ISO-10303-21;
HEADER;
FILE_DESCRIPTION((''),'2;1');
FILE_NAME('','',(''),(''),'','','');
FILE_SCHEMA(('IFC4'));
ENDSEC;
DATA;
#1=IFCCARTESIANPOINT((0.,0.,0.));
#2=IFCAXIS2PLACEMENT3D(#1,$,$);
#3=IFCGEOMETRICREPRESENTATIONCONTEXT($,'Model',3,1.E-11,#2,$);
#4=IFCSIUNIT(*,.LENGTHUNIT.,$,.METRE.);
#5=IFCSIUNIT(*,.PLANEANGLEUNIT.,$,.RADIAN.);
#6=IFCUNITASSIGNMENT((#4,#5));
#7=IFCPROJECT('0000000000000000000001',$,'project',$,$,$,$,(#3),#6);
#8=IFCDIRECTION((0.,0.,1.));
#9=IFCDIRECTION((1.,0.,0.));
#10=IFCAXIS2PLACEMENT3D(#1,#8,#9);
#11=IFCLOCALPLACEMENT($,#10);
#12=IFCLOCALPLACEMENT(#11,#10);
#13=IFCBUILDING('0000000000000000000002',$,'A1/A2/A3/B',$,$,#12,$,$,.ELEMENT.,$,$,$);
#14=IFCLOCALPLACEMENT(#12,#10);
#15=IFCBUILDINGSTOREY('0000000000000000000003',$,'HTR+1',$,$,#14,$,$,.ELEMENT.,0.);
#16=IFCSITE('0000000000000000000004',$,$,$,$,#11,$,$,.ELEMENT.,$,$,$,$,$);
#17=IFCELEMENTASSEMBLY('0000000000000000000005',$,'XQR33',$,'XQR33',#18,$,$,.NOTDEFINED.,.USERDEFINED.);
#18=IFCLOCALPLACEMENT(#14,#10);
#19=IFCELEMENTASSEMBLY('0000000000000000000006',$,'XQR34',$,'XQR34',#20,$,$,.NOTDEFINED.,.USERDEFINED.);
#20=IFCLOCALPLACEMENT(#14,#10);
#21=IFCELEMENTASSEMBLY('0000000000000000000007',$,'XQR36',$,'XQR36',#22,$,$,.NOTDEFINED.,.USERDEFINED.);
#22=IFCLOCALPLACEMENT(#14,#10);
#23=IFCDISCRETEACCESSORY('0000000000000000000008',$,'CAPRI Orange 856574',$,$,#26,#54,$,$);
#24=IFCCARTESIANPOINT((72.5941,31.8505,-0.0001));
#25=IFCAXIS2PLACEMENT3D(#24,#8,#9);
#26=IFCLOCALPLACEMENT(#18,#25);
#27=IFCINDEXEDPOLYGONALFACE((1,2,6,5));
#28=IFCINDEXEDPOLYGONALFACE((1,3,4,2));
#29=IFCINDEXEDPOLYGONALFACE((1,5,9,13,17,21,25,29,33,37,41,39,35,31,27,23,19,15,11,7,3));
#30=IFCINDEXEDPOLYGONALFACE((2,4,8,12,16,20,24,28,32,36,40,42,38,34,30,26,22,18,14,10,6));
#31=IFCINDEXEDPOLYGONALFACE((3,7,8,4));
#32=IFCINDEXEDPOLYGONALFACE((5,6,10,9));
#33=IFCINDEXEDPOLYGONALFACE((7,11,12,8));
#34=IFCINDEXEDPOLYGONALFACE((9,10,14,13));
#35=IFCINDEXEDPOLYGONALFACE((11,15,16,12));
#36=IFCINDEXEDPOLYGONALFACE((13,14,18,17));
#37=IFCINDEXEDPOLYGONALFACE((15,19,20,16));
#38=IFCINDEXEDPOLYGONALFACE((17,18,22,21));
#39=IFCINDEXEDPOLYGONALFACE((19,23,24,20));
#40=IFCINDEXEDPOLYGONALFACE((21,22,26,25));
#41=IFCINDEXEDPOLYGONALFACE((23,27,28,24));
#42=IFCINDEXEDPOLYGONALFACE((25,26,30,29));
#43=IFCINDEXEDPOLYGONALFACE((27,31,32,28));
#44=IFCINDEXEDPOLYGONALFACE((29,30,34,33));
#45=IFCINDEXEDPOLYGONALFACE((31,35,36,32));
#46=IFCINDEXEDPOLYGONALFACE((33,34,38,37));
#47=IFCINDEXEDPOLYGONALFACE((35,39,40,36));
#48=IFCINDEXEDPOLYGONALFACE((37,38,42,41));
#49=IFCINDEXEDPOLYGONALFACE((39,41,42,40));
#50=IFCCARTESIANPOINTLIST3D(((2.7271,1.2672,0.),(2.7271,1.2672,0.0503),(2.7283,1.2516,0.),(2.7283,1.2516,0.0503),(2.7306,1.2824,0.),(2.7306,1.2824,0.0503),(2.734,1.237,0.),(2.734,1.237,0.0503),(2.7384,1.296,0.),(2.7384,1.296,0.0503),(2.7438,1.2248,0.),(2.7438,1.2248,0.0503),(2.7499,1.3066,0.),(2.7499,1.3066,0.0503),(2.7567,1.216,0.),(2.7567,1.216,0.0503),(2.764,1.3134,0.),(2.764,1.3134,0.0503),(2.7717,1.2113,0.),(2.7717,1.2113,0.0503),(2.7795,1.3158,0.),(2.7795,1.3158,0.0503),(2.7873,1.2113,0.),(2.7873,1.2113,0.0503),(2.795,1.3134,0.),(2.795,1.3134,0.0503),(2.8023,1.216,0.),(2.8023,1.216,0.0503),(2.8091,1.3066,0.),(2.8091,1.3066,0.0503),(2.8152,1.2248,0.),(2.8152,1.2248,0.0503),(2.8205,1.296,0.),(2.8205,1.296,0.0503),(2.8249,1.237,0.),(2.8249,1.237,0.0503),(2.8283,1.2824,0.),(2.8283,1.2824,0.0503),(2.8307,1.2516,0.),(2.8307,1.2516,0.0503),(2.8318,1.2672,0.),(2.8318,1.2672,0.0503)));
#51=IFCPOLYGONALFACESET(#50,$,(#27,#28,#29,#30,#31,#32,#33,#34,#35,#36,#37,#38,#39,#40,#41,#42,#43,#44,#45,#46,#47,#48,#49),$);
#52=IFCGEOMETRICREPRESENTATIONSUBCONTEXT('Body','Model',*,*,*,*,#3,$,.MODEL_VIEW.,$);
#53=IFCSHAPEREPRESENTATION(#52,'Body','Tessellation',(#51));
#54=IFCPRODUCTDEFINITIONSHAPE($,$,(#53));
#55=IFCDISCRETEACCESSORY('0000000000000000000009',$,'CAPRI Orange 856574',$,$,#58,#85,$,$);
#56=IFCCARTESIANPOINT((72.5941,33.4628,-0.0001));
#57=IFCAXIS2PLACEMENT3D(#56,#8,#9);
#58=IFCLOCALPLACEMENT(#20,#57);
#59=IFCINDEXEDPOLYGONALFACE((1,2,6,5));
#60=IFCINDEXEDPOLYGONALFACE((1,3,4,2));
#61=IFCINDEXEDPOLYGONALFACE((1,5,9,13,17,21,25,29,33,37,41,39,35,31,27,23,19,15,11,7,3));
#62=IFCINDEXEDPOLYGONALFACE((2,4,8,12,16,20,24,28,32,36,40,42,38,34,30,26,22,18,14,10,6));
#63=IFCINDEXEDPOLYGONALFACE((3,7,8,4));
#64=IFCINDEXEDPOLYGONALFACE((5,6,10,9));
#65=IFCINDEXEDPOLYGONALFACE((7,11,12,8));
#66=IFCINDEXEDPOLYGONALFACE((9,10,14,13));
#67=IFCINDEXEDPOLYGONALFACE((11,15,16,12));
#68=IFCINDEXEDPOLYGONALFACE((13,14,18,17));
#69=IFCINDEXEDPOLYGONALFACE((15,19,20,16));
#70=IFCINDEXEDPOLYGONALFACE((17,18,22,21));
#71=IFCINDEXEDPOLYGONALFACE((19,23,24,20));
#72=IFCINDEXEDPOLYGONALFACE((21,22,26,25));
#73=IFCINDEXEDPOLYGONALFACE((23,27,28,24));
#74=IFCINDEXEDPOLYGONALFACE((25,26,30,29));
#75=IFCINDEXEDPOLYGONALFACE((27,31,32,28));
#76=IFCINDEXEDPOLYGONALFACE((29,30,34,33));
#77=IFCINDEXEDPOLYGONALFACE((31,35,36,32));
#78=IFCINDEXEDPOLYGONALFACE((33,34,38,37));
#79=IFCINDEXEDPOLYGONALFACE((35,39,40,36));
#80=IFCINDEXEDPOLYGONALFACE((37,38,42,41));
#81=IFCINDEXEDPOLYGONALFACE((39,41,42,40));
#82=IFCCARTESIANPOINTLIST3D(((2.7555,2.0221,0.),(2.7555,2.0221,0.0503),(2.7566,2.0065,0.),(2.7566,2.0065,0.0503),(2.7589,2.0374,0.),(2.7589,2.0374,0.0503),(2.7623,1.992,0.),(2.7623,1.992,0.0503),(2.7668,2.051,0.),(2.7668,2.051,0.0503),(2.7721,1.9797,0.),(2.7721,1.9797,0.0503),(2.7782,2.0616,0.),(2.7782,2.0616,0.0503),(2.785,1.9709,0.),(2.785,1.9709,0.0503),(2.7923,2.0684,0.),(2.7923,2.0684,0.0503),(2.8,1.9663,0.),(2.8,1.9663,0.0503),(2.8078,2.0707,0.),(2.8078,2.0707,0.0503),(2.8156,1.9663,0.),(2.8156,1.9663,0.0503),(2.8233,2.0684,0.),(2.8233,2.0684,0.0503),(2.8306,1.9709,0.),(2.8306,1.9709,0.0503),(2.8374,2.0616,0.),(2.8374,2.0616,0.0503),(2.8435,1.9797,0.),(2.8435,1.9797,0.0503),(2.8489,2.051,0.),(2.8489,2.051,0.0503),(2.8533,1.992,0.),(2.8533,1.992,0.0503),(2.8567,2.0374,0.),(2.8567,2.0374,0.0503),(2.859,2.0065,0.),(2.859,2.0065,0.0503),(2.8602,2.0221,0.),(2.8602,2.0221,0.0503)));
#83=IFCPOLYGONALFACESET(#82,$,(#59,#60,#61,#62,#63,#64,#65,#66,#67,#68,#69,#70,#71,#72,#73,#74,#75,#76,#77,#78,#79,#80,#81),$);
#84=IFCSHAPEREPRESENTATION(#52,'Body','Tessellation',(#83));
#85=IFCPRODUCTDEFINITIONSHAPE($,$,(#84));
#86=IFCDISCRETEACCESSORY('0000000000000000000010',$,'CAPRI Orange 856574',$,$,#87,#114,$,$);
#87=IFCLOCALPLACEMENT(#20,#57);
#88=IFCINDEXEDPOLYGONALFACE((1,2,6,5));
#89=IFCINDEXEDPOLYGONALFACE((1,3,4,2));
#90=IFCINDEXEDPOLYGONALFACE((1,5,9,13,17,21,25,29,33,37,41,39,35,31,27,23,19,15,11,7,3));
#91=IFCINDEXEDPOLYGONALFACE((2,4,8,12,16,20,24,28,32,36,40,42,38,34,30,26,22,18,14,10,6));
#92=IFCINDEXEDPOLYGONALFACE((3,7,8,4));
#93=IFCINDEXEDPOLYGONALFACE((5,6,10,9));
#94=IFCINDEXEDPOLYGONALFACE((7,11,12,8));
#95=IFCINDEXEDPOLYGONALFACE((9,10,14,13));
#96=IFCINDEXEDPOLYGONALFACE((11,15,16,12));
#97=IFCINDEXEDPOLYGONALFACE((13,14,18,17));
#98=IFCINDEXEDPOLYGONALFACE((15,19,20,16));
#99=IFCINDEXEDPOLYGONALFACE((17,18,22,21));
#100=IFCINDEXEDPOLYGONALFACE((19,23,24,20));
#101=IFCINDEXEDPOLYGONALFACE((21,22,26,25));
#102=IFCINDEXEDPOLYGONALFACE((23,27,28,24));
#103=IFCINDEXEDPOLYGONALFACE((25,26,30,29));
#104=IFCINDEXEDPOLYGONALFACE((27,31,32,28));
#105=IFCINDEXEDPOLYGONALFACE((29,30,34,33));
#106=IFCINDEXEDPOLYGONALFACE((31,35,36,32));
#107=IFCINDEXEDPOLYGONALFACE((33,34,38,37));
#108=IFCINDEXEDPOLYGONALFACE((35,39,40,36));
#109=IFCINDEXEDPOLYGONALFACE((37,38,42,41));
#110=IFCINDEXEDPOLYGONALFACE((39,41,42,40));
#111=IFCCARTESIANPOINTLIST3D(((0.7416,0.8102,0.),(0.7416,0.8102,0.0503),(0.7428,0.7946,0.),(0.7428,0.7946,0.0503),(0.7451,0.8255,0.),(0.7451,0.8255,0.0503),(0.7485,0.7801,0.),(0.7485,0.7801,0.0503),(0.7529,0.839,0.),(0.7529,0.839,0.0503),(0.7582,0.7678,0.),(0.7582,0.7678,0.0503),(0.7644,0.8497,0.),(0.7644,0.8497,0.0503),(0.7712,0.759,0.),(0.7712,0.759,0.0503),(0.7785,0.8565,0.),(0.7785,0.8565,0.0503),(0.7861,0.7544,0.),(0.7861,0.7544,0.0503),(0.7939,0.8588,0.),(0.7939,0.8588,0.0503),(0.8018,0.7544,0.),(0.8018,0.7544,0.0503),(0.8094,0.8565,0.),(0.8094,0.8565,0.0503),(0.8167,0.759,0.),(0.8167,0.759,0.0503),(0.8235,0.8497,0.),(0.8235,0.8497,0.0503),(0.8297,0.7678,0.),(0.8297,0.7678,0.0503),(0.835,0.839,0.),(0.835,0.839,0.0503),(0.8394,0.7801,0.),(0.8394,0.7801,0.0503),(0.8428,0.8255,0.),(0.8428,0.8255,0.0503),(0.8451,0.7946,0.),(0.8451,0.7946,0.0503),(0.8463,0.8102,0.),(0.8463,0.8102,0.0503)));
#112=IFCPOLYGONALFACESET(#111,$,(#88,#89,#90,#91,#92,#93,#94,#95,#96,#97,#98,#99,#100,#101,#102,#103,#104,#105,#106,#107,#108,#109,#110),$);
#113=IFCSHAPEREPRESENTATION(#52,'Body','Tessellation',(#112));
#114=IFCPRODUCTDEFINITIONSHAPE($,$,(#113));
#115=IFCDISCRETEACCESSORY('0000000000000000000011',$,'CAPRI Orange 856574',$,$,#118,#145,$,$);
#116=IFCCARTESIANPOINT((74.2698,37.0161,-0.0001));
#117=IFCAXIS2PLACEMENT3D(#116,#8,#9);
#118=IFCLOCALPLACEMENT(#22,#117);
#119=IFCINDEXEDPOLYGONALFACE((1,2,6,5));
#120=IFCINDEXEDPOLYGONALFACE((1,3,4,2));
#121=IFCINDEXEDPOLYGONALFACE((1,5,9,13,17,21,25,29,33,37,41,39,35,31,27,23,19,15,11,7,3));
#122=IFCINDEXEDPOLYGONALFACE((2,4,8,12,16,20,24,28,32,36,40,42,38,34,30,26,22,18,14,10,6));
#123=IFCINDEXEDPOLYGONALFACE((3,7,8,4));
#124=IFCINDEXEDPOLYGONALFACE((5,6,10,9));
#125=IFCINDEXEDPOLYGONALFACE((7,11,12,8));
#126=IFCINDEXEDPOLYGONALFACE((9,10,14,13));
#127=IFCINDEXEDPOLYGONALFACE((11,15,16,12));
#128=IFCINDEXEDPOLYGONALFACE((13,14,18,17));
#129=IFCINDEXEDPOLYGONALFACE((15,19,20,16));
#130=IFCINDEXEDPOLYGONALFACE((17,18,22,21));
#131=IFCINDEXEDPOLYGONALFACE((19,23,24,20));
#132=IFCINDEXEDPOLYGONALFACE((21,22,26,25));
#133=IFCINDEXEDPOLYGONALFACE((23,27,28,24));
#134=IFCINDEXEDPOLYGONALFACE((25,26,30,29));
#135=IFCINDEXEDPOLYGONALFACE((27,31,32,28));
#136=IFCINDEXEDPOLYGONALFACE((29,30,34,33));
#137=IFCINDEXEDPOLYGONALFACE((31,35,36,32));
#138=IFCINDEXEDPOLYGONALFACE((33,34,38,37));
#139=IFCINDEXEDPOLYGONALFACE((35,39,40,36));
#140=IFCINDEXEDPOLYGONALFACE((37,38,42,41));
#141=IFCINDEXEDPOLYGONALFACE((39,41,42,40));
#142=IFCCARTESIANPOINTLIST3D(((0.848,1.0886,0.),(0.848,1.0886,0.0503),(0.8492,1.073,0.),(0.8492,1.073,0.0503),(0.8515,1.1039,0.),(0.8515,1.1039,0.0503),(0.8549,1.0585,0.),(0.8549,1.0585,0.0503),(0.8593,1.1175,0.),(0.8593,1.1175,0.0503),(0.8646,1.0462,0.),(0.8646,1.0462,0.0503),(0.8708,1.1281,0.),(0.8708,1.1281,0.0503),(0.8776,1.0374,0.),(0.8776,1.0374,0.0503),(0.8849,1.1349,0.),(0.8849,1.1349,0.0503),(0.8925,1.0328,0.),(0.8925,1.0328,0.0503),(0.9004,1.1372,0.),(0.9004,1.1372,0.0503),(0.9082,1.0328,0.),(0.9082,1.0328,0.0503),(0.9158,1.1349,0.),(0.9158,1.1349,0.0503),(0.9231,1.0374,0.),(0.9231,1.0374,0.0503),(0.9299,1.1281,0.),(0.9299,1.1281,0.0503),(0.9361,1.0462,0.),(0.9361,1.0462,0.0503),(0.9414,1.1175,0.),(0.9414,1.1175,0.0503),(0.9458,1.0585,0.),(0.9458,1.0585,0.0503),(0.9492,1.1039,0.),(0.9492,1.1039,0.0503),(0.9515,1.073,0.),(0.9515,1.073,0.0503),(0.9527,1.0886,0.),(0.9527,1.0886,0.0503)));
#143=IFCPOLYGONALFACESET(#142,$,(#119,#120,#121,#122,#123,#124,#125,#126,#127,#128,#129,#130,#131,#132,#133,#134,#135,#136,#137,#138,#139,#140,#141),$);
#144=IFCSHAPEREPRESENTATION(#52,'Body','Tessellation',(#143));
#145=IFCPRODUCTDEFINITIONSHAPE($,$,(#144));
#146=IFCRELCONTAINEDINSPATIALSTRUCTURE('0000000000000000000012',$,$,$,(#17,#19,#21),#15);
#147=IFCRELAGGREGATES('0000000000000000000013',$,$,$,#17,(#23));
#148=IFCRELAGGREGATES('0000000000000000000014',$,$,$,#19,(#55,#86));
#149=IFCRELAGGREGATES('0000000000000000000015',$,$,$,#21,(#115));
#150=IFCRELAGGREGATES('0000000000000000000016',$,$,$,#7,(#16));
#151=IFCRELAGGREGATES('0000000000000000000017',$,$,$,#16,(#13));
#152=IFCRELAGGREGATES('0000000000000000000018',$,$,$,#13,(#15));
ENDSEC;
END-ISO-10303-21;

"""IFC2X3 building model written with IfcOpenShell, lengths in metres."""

from ifc_helpers import new_model, si_unit, frame, frame_2d, origin, origin_with_axes, place, context, subcontext, project, spatial, circle, extrude, element, aggregate, save


model = new_model("IFC2X3")

# Units and contexts
model_context = context("Model", 3, precision=1e-11, world=origin())
body_context = subcontext(model_context, "Body", "Model", "MODEL_VIEW")
ifc_project = project(units=[si_unit("LENGTHUNIT", "METRE"), si_unit("PLANEANGLEUNIT", "RADIAN")], contexts=[model_context])

# Site, building, storey
site_placement = place(None, origin_with_axes())
site = spatial("IfcSite", under=ifc_project, at=site_placement, CompositionType="ELEMENT")
building_placement = place(site_placement, origin_with_axes())
building = spatial("IfcBuilding", under=site, at=building_placement, Name="A1/A2/A3/B", CompositionType="ELEMENT")
storey_placement = place(building_placement, origin_with_axes())
storey = spatial("IfcBuildingStorey", under=building, at=storey_placement, Name="HTR+1", CompositionType="ELEMENT", Elevation=0.0)

# Element assembly
assembly_1_placement = place(storey_placement, origin_with_axes())
assembly_1 = element("IfcElementAssembly", 1, at=assembly_1_placement, inside=storey, Name="XQR33", ObjectType="XQR33", AssemblyPlace="NOTDEFINED", PredefinedType="USERDEFINED")

# Element assembly
assembly_2_placement = place(storey_placement, origin_with_axes())
assembly_2 = element("IfcElementAssembly", 2, at=assembly_2_placement, inside=storey, Name="XQR34", ObjectType="XQR34", AssemblyPlace="NOTDEFINED", PredefinedType="USERDEFINED")

# Element assembly
assembly_3_placement = place(storey_placement, origin_with_axes())
assembly_3 = element("IfcElementAssembly", 3, at=assembly_3_placement, inside=storey, Name="XQR36", ObjectType="XQR36", AssemblyPlace="NOTDEFINED", PredefinedType="USERDEFINED")

# Discrete accessory
discrete_accessory_1_placement = place(assembly_1_placement, frame((72.5941, 31.8505, -0.0001), z_axis=(0.0, 0.0, 1.0), x_axis=(1.0, 0.0, 0.0)))
discrete_accessory_1 = element("IfcDiscreteAccessory", 4, at=discrete_accessory_1_placement, Name="CAPRI Orange 856574", context=body_context, shape_type="SweptSolid", body=[
    extrude(circle(Radius=0.0525, at=frame_2d((1.2633, -2.7795), x_axis=(1.0, 0.0))), frame((0.0, 0.0, 0.0), z_axis=(0.0, 0.0, 1.0), x_axis=(0.0, 1.0, 0.0)), (0.0, 0.0, 1.0), 0.0503),
])

aggregate(assembly_1, [discrete_accessory_1])

# Discrete accessories
discrete_accessory_2_placement = place(assembly_2_placement, frame((72.5941, 33.4628, -0.0001), z_axis=(0.0, 0.0, 1.0), x_axis=(1.0, 0.0, 0.0)))
discrete_accessory_2 = element("IfcDiscreteAccessory", 5, at=discrete_accessory_2_placement, Name="CAPRI Orange 856574", context=body_context, shape_type="SweptSolid", body=[
    extrude(circle(Radius=0.0525, at=frame_2d((2.0182, -2.8078), x_axis=(1.0, 0.0))), frame((0.0, 0.0, 0.0), z_axis=(0.0, 0.0, 1.0), x_axis=(0.0, 1.0, 0.0)), (0.0, 0.0, 1.0), 0.0503),
])
discrete_accessory_3_placement = place(assembly_2_placement, frame((72.5941, 33.4628, -0.0001), z_axis=(0.0, 0.0, 1.0), x_axis=(1.0, 0.0, 0.0)))
discrete_accessory_3 = element("IfcDiscreteAccessory", 6, at=discrete_accessory_3_placement, Name="CAPRI Orange 856574", context=body_context, shape_type="SweptSolid", body=[
    extrude(circle(Radius=0.0525, at=frame_2d((0.8063, -0.7939), x_axis=(1.0, 0.0))), frame((0.0, 0.0, 0.0), z_axis=(0.0, 0.0, 1.0), x_axis=(0.0, 1.0, 0.0)), (0.0, 0.0, 1.0), 0.0503),
])

aggregate(assembly_2, [discrete_accessory_2, discrete_accessory_3])

# Discrete accessory
discrete_accessory_4_placement = place(assembly_3_placement, frame((74.2698, 37.0161, -0.0001), z_axis=(0.0, 0.0, 1.0), x_axis=(1.0, 0.0, 0.0)))
discrete_accessory_4 = element("IfcDiscreteAccessory", 7, at=discrete_accessory_4_placement, Name="CAPRI Orange 856574", context=body_context, shape_type="SweptSolid", body=[
    extrude(circle(Radius=0.0525, at=frame_2d((1.0847, -0.9004), x_axis=(1.0, 0.0))), frame((0.0, 0.0, 0.0), z_axis=(0.0, 0.0, 1.0), x_axis=(0.0, 1.0, 0.0)), (0.0, 0.0, 1.0), 0.0503),
])
aggregate(assembly_3, [discrete_accessory_4])

save(model, "model.ifc")
